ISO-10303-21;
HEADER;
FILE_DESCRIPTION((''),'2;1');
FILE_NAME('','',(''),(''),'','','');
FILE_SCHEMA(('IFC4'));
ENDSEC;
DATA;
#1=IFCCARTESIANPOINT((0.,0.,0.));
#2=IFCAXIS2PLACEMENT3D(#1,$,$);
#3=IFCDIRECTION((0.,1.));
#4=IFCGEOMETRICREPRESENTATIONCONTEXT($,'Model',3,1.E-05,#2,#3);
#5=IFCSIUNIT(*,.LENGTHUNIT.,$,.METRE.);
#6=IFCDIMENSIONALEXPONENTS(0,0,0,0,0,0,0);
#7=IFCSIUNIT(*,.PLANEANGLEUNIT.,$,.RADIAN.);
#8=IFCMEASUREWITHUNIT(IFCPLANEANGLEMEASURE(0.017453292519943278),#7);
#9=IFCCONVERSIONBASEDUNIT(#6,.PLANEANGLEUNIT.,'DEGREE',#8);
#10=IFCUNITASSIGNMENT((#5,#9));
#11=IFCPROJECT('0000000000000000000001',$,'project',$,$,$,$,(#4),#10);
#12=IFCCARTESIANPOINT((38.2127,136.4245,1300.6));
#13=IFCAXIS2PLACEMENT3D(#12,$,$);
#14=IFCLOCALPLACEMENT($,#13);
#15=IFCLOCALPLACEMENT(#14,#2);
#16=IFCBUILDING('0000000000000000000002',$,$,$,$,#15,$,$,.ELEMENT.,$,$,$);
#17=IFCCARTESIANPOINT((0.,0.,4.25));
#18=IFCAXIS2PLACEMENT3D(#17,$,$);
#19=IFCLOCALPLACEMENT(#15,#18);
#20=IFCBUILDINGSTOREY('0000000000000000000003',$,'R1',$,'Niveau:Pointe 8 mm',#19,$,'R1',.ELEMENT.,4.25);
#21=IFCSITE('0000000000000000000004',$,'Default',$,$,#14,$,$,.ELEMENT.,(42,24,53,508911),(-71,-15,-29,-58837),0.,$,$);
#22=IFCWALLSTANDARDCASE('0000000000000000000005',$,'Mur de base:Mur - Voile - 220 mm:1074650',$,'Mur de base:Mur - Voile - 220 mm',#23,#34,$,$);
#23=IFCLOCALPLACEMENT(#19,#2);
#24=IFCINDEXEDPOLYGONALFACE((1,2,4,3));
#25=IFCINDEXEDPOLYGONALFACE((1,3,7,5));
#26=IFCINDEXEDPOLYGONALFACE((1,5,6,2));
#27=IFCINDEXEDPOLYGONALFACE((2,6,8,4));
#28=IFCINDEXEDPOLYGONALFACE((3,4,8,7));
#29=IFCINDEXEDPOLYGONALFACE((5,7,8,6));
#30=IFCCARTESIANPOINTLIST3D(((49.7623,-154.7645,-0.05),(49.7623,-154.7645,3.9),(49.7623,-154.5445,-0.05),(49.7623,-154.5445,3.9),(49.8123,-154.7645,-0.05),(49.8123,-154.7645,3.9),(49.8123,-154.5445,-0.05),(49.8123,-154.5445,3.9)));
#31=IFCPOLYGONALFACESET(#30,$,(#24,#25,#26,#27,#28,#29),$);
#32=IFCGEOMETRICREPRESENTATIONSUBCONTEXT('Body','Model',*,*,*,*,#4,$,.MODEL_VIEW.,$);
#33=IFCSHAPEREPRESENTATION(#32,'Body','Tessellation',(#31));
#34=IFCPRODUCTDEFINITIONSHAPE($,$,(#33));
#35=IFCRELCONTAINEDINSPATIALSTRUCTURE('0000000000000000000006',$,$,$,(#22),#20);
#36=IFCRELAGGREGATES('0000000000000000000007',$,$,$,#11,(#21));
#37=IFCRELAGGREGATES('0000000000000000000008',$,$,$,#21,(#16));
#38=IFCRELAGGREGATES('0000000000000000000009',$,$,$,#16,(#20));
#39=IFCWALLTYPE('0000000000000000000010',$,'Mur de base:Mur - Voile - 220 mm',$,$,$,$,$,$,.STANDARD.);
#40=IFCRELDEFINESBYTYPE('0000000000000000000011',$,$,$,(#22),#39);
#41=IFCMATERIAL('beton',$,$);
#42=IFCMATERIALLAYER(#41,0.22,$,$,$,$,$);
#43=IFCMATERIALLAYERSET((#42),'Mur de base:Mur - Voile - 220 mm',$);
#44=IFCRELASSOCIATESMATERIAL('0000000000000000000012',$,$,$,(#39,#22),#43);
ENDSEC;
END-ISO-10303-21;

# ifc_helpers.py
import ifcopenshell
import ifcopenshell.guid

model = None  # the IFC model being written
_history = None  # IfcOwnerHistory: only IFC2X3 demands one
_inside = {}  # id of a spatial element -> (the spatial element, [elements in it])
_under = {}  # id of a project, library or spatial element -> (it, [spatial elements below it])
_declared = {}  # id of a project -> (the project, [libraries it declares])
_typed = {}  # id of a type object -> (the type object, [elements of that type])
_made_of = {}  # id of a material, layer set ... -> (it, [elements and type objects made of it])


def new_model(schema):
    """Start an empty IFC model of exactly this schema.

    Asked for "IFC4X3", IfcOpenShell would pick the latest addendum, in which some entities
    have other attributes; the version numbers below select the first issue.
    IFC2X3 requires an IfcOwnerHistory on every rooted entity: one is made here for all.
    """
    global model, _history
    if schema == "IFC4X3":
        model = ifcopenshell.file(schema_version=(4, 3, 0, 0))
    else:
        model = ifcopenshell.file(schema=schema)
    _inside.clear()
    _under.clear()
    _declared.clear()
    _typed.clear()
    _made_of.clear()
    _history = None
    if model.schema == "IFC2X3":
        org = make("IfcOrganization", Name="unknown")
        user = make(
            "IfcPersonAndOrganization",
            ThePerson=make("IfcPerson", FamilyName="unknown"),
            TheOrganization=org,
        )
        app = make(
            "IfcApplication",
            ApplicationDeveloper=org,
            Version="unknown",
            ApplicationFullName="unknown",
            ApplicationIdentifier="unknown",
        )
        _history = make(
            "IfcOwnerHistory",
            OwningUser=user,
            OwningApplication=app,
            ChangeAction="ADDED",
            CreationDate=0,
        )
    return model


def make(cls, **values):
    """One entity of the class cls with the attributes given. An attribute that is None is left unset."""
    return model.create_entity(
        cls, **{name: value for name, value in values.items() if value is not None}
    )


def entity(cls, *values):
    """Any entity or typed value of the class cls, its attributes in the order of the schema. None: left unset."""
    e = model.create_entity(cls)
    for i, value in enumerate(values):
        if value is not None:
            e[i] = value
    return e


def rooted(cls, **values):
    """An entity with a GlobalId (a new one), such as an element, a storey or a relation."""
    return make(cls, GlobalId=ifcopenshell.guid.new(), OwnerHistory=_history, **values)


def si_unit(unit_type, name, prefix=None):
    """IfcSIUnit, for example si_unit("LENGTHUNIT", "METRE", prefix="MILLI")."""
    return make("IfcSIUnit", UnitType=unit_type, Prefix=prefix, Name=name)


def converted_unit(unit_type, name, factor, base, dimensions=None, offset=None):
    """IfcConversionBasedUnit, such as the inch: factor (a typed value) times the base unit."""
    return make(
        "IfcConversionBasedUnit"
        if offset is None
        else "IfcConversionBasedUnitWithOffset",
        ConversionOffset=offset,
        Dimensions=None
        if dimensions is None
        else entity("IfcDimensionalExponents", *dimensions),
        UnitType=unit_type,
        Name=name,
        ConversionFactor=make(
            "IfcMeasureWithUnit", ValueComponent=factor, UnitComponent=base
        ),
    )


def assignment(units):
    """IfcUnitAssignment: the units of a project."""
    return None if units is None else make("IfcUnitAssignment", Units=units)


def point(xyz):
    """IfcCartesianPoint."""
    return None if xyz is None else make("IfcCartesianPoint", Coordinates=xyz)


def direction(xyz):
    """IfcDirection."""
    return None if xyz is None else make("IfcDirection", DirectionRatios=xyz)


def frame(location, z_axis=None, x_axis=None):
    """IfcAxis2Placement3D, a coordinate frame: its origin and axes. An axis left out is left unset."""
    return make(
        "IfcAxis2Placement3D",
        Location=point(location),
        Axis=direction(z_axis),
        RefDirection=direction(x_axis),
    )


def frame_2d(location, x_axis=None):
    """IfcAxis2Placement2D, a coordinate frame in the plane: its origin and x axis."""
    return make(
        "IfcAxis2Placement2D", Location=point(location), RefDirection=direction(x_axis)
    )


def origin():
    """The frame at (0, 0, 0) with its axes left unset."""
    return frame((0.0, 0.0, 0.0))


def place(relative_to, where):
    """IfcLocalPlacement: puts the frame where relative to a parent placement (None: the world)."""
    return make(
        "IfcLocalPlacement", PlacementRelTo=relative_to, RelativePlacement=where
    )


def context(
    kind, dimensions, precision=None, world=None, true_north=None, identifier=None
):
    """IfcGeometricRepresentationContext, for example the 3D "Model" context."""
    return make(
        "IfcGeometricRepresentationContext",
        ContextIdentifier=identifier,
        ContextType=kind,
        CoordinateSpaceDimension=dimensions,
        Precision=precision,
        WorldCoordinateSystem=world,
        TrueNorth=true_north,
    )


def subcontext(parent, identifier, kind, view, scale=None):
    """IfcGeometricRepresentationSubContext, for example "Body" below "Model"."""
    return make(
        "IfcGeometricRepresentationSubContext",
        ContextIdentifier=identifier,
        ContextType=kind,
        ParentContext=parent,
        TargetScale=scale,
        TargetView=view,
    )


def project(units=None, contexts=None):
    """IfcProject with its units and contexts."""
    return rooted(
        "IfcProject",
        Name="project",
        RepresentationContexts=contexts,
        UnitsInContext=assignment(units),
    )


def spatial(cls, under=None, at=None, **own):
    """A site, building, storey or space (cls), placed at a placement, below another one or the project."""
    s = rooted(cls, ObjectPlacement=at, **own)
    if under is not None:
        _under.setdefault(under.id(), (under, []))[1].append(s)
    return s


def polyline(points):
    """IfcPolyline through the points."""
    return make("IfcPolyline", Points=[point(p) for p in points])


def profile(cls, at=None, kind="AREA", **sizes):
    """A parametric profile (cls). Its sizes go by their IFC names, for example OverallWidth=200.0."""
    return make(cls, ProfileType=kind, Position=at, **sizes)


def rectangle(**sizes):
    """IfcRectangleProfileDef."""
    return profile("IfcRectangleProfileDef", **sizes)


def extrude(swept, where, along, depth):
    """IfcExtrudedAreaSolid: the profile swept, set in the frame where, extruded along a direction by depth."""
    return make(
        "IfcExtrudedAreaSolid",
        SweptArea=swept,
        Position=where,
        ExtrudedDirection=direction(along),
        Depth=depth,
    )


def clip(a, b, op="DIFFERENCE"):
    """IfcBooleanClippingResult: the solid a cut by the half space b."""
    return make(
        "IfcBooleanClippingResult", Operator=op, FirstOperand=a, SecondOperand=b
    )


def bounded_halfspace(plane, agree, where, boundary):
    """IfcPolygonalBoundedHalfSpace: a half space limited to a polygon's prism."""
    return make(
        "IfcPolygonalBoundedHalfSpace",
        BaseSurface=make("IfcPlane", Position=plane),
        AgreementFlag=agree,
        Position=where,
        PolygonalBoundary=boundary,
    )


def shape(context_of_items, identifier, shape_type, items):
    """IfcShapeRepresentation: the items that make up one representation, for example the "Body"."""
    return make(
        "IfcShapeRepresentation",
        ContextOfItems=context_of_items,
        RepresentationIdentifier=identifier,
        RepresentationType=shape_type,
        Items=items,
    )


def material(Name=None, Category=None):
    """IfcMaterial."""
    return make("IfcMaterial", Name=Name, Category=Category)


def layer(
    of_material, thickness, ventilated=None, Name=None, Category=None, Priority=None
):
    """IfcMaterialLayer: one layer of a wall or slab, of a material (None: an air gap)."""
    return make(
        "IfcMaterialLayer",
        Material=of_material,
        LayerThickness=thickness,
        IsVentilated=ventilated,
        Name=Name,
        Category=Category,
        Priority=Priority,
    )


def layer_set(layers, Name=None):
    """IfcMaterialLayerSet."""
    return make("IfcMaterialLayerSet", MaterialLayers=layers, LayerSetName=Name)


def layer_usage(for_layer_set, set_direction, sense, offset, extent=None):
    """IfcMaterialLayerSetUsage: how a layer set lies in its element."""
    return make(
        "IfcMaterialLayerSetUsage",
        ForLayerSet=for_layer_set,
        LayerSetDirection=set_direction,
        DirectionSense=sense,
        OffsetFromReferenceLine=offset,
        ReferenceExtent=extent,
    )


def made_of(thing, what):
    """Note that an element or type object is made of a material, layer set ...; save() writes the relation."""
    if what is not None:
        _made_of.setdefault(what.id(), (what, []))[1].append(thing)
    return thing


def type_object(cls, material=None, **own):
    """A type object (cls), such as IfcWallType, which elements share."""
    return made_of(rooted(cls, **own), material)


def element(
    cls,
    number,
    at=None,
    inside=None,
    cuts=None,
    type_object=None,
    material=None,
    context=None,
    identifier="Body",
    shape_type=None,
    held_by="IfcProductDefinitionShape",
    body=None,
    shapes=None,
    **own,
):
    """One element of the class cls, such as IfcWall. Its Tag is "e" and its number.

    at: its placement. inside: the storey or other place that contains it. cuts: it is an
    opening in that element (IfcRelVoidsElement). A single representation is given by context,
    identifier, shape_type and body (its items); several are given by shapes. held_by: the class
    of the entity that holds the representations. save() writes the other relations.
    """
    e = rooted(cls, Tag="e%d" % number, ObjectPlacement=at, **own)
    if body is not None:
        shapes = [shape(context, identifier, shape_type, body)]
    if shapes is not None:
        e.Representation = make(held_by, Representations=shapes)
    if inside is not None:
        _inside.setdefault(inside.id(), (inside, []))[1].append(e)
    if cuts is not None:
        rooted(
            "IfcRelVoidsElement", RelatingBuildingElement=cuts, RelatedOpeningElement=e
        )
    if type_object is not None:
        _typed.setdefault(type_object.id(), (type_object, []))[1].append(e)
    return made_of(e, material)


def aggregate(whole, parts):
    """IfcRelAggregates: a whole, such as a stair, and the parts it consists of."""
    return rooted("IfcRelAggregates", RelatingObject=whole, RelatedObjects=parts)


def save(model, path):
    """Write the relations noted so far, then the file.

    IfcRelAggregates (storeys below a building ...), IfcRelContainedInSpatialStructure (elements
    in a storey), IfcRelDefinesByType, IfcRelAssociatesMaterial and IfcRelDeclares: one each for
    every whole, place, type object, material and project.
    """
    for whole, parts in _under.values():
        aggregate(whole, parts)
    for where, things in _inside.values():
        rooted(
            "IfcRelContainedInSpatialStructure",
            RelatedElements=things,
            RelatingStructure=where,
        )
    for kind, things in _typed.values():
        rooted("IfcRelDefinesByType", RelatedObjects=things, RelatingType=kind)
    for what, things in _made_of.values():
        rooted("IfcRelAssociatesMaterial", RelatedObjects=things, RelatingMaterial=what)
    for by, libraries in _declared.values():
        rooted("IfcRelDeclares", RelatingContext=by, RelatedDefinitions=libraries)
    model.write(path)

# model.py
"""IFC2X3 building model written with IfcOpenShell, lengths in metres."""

from ifc_helpers import new_model, entity, si_unit, converted_unit, direction, frame, frame_2d, origin, place, context, subcontext, project, spatial, polyline, rectangle, extrude, clip, bounded_halfspace, material, layer, layer_set, layer_usage, type_object, element, save


model = new_model("IFC2X3")

# Units and contexts
model_context = context("Model", 3, precision=1e-05, world=origin(), true_north=direction((0.0, 1.0)))
body_context = subcontext(model_context, "Body", "Model", "MODEL_VIEW")
ifc_project = project(units=[si_unit("LENGTHUNIT", "METRE"), converted_unit("PLANEANGLEUNIT", "DEGREE", entity("IfcPlaneAngleMeasure", 0.017453292519943278), si_unit("PLANEANGLEUNIT", "RADIAN"), dimensions=[0, 0, 0, 0, 0, 0, 0])], contexts=[model_context])

# Site, building, storey
site_placement = place(None, frame((38.2127, 136.4245, 1300.6)))
site = spatial("IfcSite", under=ifc_project, at=site_placement, Name="Default", CompositionType="ELEMENT", RefLatitude=(42, 24, 53, 508911), RefLongitude=(-71, -15, -29, -58837), RefElevation=0.0)
building_placement = place(site_placement, origin())
building = spatial("IfcBuilding", under=site, at=building_placement, CompositionType="ELEMENT")
storey_placement = place(building_placement, frame((0.0, 0.0, 4.25)))
storey = spatial("IfcBuildingStorey", under=building, at=storey_placement, Name="R1", ObjectType="Niveau:Pointe 8 mm", LongName="R1", CompositionType="ELEMENT", Elevation=4.25)

# Shared definitions
ifc_material = material(Name="beton")
ifc_layer = layer(ifc_material, 0.22)
ifc_layer_set = layer_set([ifc_layer], Name="Mur de base:Mur - Voile - 220 mm")
wall_type = type_object("IfcWallType", Name="Mur de base:Mur - Voile - 220 mm", PredefinedType="STANDARD", material=ifc_layer_set)

# Wall
ifc_layer_usage_1 = layer_usage(ifc_layer_set, "AXIS2", "NEGATIVE", 0.11)
wall_1_placement = place(storey_placement, frame((49.7623, -154.6545, -0.05)))
element("IfcWallStandardCase", 1, at=wall_1_placement, inside=storey, type_object=wall_type, material=ifc_layer_usage_1, Name="Mur de base:Mur - Voile - 220 mm:1074650", ObjectType="Mur de base:Mur - Voile - 220 mm", context=body_context, shape_type="Clipping", body=[
    clip(extrude(rectangle(XDim=0.05, YDim=0.22, at=frame_2d((0.025, 0.0), x_axis=(-1.0, 0.0))), origin(), (0.0, 0.0, 1.0), 3.95), bounded_halfspace(frame((0.0, -0.11, 3.95), z_axis=(0.0, 0.0, -1.0), x_axis=(1.0, 0.0, 0.0)), True, frame((0.0, -0.11, 3.95)), polyline([(0.0, 0.0), (0.005, 0.0), (0.005, 0.22), (0.0, 0.22), (0.0, 0.0)]))),
])

save(model, "model.ifc")
